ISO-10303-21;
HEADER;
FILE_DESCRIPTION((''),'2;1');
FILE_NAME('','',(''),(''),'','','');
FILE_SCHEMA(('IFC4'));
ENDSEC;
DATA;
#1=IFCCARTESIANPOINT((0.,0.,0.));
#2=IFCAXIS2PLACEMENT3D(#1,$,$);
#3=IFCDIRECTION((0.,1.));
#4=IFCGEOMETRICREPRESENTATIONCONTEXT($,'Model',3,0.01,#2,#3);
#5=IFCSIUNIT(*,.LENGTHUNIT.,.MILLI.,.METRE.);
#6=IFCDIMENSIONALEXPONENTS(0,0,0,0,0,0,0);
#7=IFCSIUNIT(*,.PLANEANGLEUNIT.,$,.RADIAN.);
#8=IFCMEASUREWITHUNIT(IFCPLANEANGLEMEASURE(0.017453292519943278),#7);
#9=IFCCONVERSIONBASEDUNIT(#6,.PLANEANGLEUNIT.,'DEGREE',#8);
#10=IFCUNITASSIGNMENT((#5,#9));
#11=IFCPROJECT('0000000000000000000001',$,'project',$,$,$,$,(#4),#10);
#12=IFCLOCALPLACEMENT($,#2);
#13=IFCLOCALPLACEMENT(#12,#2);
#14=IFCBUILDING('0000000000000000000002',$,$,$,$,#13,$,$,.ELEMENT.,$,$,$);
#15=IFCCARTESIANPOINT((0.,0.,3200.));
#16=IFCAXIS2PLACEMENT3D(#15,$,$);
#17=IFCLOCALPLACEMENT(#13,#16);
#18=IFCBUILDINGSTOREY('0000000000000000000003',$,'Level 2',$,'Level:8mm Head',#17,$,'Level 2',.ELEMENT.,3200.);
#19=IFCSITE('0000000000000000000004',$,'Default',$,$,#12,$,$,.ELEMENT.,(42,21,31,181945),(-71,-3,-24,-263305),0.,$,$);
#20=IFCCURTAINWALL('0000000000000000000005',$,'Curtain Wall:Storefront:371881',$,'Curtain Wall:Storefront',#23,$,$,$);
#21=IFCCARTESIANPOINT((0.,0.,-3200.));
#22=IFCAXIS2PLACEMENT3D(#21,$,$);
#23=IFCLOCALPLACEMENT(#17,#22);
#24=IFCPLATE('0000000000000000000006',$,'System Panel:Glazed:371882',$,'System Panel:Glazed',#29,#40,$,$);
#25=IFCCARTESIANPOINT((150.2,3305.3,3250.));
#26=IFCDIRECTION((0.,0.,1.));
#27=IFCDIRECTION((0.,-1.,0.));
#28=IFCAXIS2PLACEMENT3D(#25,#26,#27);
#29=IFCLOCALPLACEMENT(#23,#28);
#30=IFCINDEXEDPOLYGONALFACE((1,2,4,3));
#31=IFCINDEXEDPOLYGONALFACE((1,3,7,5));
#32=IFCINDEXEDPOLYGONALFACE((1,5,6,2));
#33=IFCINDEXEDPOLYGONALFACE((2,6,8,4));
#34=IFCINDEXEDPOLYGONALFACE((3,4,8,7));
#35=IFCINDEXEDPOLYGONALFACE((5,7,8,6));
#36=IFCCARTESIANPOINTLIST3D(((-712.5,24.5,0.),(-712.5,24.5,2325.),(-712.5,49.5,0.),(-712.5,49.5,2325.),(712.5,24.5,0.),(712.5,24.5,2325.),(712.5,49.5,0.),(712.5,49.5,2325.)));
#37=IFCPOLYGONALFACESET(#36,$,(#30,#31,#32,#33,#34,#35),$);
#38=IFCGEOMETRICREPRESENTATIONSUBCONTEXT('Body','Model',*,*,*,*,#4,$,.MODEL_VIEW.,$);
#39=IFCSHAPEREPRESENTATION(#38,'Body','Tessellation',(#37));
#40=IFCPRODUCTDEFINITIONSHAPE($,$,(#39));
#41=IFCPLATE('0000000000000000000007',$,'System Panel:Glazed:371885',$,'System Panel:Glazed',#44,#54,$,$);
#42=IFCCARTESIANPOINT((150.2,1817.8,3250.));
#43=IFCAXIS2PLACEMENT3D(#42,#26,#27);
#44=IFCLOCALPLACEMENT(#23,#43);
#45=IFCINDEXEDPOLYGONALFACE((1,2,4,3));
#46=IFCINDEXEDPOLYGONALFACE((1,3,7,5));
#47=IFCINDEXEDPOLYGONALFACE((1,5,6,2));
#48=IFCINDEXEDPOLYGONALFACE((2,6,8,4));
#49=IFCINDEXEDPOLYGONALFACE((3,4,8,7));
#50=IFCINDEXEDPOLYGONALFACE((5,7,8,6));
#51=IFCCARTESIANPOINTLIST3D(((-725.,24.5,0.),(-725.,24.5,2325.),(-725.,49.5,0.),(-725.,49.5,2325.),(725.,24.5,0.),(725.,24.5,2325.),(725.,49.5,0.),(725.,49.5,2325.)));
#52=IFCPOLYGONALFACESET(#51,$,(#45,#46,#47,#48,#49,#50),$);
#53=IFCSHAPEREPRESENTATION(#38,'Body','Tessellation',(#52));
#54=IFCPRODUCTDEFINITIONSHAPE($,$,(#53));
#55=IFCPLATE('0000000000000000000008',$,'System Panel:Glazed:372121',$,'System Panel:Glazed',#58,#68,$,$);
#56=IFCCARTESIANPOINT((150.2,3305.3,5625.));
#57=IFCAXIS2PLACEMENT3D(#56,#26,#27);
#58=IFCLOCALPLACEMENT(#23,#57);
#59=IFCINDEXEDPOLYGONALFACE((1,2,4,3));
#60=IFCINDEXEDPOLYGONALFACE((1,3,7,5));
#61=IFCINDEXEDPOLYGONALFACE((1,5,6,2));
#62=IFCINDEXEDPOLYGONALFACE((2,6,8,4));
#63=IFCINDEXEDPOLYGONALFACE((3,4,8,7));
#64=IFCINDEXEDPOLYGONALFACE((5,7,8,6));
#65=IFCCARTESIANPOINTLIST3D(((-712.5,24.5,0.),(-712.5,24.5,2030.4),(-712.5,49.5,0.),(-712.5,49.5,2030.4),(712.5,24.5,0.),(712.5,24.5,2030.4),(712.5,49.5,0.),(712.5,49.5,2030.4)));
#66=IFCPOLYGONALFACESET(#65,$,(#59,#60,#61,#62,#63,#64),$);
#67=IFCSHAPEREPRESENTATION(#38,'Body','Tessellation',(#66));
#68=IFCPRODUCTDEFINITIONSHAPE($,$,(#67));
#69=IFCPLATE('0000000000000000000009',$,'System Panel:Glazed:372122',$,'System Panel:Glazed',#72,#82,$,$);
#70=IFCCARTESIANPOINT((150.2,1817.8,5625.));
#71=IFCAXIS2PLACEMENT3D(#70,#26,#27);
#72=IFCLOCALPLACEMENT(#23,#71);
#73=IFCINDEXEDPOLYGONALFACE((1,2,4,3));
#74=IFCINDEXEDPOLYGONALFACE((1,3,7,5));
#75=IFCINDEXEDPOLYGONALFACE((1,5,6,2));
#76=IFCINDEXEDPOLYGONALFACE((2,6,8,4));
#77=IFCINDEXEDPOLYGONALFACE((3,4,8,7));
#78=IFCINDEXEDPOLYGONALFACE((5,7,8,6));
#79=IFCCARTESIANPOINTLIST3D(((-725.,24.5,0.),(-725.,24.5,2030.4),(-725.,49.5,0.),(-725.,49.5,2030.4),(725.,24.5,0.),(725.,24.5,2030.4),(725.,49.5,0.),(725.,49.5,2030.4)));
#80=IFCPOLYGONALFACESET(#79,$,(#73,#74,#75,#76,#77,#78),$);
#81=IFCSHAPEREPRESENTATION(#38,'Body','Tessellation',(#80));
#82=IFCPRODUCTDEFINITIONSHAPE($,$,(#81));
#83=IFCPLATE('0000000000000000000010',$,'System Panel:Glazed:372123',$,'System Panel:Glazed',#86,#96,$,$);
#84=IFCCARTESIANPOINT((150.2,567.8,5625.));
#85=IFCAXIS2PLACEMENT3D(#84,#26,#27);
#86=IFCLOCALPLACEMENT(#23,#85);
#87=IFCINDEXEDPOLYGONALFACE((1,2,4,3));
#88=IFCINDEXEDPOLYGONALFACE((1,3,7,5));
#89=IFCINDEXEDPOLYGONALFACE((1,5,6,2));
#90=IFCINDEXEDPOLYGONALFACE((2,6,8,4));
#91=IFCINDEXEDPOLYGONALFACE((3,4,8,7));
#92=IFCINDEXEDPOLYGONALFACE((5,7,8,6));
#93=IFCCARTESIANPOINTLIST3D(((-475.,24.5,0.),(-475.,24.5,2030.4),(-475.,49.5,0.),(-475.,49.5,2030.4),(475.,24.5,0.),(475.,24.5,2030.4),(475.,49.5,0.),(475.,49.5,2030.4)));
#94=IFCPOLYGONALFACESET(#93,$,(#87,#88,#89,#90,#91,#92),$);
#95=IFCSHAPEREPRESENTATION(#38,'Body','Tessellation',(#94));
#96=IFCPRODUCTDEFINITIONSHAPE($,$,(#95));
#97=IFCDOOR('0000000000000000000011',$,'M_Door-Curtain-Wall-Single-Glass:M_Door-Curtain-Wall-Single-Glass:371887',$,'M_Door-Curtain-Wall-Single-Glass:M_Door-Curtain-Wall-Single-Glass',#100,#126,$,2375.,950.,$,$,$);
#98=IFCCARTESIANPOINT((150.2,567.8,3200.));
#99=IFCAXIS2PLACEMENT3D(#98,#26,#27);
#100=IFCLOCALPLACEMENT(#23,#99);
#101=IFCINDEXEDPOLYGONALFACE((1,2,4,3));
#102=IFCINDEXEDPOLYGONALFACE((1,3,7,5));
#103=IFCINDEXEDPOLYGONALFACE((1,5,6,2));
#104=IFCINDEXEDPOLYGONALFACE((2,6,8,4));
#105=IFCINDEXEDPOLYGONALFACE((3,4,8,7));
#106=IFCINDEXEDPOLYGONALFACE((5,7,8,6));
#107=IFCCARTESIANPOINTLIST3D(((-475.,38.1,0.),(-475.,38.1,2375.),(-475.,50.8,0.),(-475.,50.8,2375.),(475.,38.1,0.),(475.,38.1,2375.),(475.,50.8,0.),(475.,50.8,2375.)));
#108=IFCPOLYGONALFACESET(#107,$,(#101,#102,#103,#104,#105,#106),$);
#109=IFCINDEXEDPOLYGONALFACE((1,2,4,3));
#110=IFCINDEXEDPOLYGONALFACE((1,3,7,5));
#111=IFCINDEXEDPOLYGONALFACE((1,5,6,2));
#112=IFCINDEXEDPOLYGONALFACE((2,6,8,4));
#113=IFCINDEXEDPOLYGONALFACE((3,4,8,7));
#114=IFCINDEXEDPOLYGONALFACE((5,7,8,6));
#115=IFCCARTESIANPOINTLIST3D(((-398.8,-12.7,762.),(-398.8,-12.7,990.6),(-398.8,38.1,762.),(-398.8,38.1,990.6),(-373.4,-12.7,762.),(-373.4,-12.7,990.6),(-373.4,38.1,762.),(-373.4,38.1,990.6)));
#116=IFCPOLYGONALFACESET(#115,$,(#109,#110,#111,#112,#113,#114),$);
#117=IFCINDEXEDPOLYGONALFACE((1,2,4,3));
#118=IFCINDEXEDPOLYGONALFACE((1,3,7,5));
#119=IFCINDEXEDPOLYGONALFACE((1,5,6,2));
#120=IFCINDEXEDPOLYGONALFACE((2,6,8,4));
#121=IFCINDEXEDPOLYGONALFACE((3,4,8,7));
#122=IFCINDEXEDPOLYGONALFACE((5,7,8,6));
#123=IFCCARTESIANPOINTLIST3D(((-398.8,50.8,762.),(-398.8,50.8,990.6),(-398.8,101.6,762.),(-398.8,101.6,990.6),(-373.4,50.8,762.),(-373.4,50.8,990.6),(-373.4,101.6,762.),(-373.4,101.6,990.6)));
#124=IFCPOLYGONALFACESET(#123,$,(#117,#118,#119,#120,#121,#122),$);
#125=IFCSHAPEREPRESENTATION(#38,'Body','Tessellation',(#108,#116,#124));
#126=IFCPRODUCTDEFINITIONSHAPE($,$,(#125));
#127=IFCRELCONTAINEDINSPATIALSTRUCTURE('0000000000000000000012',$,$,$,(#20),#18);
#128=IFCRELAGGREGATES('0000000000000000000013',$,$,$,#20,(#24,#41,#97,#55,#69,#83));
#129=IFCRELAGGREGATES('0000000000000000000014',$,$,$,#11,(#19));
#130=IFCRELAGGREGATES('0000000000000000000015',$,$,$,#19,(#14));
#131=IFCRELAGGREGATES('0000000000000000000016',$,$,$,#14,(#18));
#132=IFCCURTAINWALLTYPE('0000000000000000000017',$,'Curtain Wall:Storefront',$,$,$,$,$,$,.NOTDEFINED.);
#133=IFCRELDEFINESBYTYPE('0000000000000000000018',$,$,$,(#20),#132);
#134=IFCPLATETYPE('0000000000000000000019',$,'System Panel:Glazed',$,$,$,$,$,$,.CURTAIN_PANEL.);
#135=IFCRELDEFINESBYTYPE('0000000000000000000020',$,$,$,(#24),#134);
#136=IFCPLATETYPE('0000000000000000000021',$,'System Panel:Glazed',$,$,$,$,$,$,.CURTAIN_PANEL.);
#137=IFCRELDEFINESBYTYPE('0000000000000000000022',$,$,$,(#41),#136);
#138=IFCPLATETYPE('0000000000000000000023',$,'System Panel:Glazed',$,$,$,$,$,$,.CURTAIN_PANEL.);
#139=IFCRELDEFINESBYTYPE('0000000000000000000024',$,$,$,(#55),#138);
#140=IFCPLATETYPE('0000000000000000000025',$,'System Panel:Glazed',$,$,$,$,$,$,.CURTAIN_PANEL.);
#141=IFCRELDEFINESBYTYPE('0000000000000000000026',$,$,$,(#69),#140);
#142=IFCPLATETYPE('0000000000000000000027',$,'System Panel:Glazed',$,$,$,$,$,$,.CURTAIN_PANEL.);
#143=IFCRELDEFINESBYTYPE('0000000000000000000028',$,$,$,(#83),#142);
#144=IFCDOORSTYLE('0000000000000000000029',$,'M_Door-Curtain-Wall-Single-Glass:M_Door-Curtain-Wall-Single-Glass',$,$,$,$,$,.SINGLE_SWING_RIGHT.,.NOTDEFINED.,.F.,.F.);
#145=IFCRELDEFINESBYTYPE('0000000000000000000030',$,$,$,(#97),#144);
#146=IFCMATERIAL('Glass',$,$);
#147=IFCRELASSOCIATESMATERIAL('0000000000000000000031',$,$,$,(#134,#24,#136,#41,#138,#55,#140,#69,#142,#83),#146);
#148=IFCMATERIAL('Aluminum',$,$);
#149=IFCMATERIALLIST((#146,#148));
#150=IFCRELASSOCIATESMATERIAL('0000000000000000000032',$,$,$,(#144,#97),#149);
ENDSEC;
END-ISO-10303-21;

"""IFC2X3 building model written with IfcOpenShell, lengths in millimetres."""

from ifc_helpers import new_model, entity, si_unit, converted_unit, direction, frame, frame_2d, origin, origin_2d_with_axis, place, context, subcontext, project, spatial, rectangle, extrude, source, transform, mapped, material, material_list, type_object, type_shapes, element, aggregate, save


model = new_model("IFC2X3")

# Units and contexts
model_context = context("Model", 3, precision=0.01, world=origin(), true_north=direction((0.0, 1.0)))
body_context = subcontext(model_context, "Body", "Model", "MODEL_VIEW")
ifc_project = project(units=[si_unit("LENGTHUNIT", "METRE", prefix="MILLI"), converted_unit("PLANEANGLEUNIT", "DEGREE", entity("IfcPlaneAngleMeasure", 0.017453292519943278), si_unit("PLANEANGLEUNIT", "RADIAN"), dimensions=[0, 0, 0, 0, 0, 0, 0])], contexts=[model_context])

# Site, building, storey
site_placement = place(None, origin())
site = spatial("IfcSite", under=ifc_project, at=site_placement, Name="Default", CompositionType="ELEMENT", RefLatitude=(42, 21, 31, 181945), RefLongitude=(-71, -3, -24, -263305), RefElevation=0.0)
building_placement = place(site_placement, origin())
building = spatial("IfcBuilding", under=site, at=building_placement, CompositionType="ELEMENT")
storey_placement = place(building_placement, frame((0.0, 0.0, 3200.0)))
storey = spatial("IfcBuildingStorey", under=building, at=storey_placement, Name="Level 2", ObjectType="Level:8mm Head", LongName="Level 2", CompositionType="ELEMENT", Elevation=3200.0)

# Curtain wall, plates
curtain_wall_type = type_object("IfcCurtainWallType", Name="Curtain Wall:Storefront", PredefinedType="NOTDEFINED")
curtain_wall_placement = place(storey_placement, frame((0.0, 0.0, -3200.0)))
curtain_wall = element("IfcCurtainWall", 1, at=curtain_wall_placement, inside=storey, type_object=curtain_wall_type, Name="Curtain Wall:Storefront:371881", ObjectType="Curtain Wall:Storefront")
ifc_material_1 = material(Name="Glass")
plate_type_1 = type_object("IfcPlateType", Name="System Panel:Glazed", PredefinedType="CURTAIN_PANEL", material=ifc_material_1)
shared_shape_1 = source(origin(), body_context, "Body", "SweptSolid", [
    extrude(rectangle(XDim=25.0, YDim=1425.0, at=origin_2d_with_axis()), frame((0.0, 37.0, 0.0), z_axis=(0.0, 0.0, 1.0), x_axis=(0.0, 1.0, 0.0)), (0.0, 0.0, 1.0), 2325.0),
])
type_shapes(plate_type_1, [shared_shape_1])
plate_1_placement = place(curtain_wall_placement, frame((150.2, 3305.3, 3250.0), z_axis=(0.0, 0.0, 1.0), x_axis=(0.0, -1.0, 0.0)))
plate_1 = element("IfcPlate", 2, at=plate_1_placement, type_object=plate_type_1, material=ifc_material_1, Name="System Panel:Glazed:371882", ObjectType="System Panel:Glazed", context=body_context, shape_type="MappedRepresentation", body=[
    mapped(shared_shape_1, transform((0.0, 0.0, 0.0), scale=1.0)),
])
plate_type_2 = type_object("IfcPlateType", Name="System Panel:Glazed", PredefinedType="CURTAIN_PANEL", material=ifc_material_1)
shared_shape_2 = source(origin(), body_context, "Body", "SweptSolid", [
    extrude(rectangle(XDim=25.0, YDim=1450.0, at=origin_2d_with_axis()), frame((0.0, 37.0, 0.0), z_axis=(0.0, 0.0, 1.0), x_axis=(0.0, 1.0, 0.0)), (0.0, 0.0, 1.0), 2325.0),
])
type_shapes(plate_type_2, [shared_shape_2])
plate_2_placement = place(curtain_wall_placement, frame((150.2, 1817.8, 3250.0), z_axis=(0.0, 0.0, 1.0), x_axis=(0.0, -1.0, 0.0)))
plate_2 = element("IfcPlate", 3, at=plate_2_placement, type_object=plate_type_2, material=ifc_material_1, Name="System Panel:Glazed:371885", ObjectType="System Panel:Glazed", context=body_context, shape_type="MappedRepresentation", body=[
    mapped(shared_shape_2, transform((0.0, 0.0, 0.0), scale=1.0)),
])
plate_type_3 = type_object("IfcPlateType", Name="System Panel:Glazed", PredefinedType="CURTAIN_PANEL", material=ifc_material_1)
shared_shape_3 = source(origin(), body_context, "Body", "SweptSolid", [
    extrude(rectangle(XDim=25.0, YDim=1425.0, at=origin_2d_with_axis()), frame((0.0, 37.0, 0.0), z_axis=(0.0, 0.0, 1.0), x_axis=(0.0, 1.0, 0.0)), (0.0, 0.0, 1.0), 2030.4),
])
type_shapes(plate_type_3, [shared_shape_3])
plate_3_placement = place(curtain_wall_placement, frame((150.2, 3305.3, 5625.0), z_axis=(0.0, 0.0, 1.0), x_axis=(0.0, -1.0, 0.0)))
plate_3 = element("IfcPlate", 4, at=plate_3_placement, type_object=plate_type_3, material=ifc_material_1, Name="System Panel:Glazed:372121", ObjectType="System Panel:Glazed", context=body_context, shape_type="MappedRepresentation", body=[
    mapped(shared_shape_3, transform((0.0, 0.0, 0.0), scale=1.0)),
])
plate_type_4 = type_object("IfcPlateType", Name="System Panel:Glazed", PredefinedType="CURTAIN_PANEL", material=ifc_material_1)
shared_shape_4 = source(origin(), body_context, "Body", "SweptSolid", [
    extrude(rectangle(XDim=25.0, YDim=1450.0, at=origin_2d_with_axis()), frame((0.0, 37.0, 0.0), z_axis=(0.0, 0.0, 1.0), x_axis=(0.0, 1.0, 0.0)), (0.0, 0.0, 1.0), 2030.4),
])
type_shapes(plate_type_4, [shared_shape_4])
plate_4_placement = place(curtain_wall_placement, frame((150.2, 1817.8, 5625.0), z_axis=(0.0, 0.0, 1.0), x_axis=(0.0, -1.0, 0.0)))
plate_4 = element("IfcPlate", 5, at=plate_4_placement, type_object=plate_type_4, material=ifc_material_1, Name="System Panel:Glazed:372122", ObjectType="System Panel:Glazed", context=body_context, shape_type="MappedRepresentation", body=[
    mapped(shared_shape_4, transform((0.0, 0.0, 0.0), scale=1.0)),
])
plate_type_5 = type_object("IfcPlateType", Name="System Panel:Glazed", PredefinedType="CURTAIN_PANEL", material=ifc_material_1)
shared_shape_5 = source(origin(), body_context, "Body", "SweptSolid", [
    extrude(rectangle(XDim=25.0, YDim=950.0, at=origin_2d_with_axis()), frame((0.0, 37.0, 0.0), z_axis=(0.0, 0.0, 1.0), x_axis=(0.0, 1.0, 0.0)), (0.0, 0.0, 1.0), 2030.4),
])
type_shapes(plate_type_5, [shared_shape_5])
plate_5_placement = place(curtain_wall_placement, frame((150.2, 567.8, 5625.0), z_axis=(0.0, 0.0, 1.0), x_axis=(0.0, -1.0, 0.0)))
plate_5 = element("IfcPlate", 6, at=plate_5_placement, type_object=plate_type_5, material=ifc_material_1, Name="System Panel:Glazed:372123", ObjectType="System Panel:Glazed", context=body_context, shape_type="MappedRepresentation", body=[
    mapped(shared_shape_5, transform((0.0, 0.0, 0.0), scale=1.0)),
])

# Door
ifc_material_2 = material(Name="Aluminum")
ifc_material_list = material_list([ifc_material_1, ifc_material_2])
door_style = type_object("IfcDoorStyle", Name="M_Door-Curtain-Wall-Single-Glass:M_Door-Curtain-Wall-Single-Glass", ConstructionType="NOTDEFINED", OperationType="SINGLE_SWING_RIGHT", ParameterTakesPrecedence=False, Sizeable=False, material=ifc_material_list)
shared_shape_6 = source(origin(), body_context, "Body", "SweptSolid", [
    extrude(rectangle(XDim=950.0, YDim=12.7, at=frame_2d((0.0, 0.0), x_axis=(1.0, 0.0))), frame((0.0, 44.5, 0.0), z_axis=(0.0, 0.0, 1.0), x_axis=(-1.0, 0.0, 0.0)), (0.0, 0.0, 1.0), 2375.0),
    extrude(rectangle(XDim=50.8, YDim=25.4, at=frame_2d((0.0, 0.0), x_axis=(1.0, 0.0))), frame((-386.1, 12.7, 762.0), z_axis=(0.0, 0.0, 1.0), x_axis=(0.0, 1.0, 0.0)), (0.0, 0.0, 1.0), 228.6),
    extrude(rectangle(XDim=50.8, YDim=25.4, at=frame_2d((0.0, 0.0), x_axis=(1.0, 0.0))), frame((-386.1, 76.2, 762.0), z_axis=(0.0, 0.0, 1.0), x_axis=(0.0, -1.0, 0.0)), (0.0, 0.0, 1.0), 228.6),
])
type_shapes(door_style, [shared_shape_6])
door_placement = place(curtain_wall_placement, frame((150.2, 567.8, 3200.0), z_axis=(0.0, 0.0, 1.0), x_axis=(0.0, -1.0, 0.0)))
door = element("IfcDoor", 7, at=door_placement, type_object=door_style, material=ifc_material_list, Name="M_Door-Curtain-Wall-Single-Glass:M_Door-Curtain-Wall-Single-Glass:371887", ObjectType="M_Door-Curtain-Wall-Single-Glass:M_Door-Curtain-Wall-Single-Glass", OverallHeight=2375.0, OverallWidth=950.0, context=body_context, shape_type="MappedRepresentation", body=[
    mapped(shared_shape_6, transform((0.0, 0.0, 0.0), scale=1.0)),
])
aggregate(curtain_wall, [plate_1, plate_2, door, plate_3, plate_4, plate_5])

save(model, "model.ifc")
